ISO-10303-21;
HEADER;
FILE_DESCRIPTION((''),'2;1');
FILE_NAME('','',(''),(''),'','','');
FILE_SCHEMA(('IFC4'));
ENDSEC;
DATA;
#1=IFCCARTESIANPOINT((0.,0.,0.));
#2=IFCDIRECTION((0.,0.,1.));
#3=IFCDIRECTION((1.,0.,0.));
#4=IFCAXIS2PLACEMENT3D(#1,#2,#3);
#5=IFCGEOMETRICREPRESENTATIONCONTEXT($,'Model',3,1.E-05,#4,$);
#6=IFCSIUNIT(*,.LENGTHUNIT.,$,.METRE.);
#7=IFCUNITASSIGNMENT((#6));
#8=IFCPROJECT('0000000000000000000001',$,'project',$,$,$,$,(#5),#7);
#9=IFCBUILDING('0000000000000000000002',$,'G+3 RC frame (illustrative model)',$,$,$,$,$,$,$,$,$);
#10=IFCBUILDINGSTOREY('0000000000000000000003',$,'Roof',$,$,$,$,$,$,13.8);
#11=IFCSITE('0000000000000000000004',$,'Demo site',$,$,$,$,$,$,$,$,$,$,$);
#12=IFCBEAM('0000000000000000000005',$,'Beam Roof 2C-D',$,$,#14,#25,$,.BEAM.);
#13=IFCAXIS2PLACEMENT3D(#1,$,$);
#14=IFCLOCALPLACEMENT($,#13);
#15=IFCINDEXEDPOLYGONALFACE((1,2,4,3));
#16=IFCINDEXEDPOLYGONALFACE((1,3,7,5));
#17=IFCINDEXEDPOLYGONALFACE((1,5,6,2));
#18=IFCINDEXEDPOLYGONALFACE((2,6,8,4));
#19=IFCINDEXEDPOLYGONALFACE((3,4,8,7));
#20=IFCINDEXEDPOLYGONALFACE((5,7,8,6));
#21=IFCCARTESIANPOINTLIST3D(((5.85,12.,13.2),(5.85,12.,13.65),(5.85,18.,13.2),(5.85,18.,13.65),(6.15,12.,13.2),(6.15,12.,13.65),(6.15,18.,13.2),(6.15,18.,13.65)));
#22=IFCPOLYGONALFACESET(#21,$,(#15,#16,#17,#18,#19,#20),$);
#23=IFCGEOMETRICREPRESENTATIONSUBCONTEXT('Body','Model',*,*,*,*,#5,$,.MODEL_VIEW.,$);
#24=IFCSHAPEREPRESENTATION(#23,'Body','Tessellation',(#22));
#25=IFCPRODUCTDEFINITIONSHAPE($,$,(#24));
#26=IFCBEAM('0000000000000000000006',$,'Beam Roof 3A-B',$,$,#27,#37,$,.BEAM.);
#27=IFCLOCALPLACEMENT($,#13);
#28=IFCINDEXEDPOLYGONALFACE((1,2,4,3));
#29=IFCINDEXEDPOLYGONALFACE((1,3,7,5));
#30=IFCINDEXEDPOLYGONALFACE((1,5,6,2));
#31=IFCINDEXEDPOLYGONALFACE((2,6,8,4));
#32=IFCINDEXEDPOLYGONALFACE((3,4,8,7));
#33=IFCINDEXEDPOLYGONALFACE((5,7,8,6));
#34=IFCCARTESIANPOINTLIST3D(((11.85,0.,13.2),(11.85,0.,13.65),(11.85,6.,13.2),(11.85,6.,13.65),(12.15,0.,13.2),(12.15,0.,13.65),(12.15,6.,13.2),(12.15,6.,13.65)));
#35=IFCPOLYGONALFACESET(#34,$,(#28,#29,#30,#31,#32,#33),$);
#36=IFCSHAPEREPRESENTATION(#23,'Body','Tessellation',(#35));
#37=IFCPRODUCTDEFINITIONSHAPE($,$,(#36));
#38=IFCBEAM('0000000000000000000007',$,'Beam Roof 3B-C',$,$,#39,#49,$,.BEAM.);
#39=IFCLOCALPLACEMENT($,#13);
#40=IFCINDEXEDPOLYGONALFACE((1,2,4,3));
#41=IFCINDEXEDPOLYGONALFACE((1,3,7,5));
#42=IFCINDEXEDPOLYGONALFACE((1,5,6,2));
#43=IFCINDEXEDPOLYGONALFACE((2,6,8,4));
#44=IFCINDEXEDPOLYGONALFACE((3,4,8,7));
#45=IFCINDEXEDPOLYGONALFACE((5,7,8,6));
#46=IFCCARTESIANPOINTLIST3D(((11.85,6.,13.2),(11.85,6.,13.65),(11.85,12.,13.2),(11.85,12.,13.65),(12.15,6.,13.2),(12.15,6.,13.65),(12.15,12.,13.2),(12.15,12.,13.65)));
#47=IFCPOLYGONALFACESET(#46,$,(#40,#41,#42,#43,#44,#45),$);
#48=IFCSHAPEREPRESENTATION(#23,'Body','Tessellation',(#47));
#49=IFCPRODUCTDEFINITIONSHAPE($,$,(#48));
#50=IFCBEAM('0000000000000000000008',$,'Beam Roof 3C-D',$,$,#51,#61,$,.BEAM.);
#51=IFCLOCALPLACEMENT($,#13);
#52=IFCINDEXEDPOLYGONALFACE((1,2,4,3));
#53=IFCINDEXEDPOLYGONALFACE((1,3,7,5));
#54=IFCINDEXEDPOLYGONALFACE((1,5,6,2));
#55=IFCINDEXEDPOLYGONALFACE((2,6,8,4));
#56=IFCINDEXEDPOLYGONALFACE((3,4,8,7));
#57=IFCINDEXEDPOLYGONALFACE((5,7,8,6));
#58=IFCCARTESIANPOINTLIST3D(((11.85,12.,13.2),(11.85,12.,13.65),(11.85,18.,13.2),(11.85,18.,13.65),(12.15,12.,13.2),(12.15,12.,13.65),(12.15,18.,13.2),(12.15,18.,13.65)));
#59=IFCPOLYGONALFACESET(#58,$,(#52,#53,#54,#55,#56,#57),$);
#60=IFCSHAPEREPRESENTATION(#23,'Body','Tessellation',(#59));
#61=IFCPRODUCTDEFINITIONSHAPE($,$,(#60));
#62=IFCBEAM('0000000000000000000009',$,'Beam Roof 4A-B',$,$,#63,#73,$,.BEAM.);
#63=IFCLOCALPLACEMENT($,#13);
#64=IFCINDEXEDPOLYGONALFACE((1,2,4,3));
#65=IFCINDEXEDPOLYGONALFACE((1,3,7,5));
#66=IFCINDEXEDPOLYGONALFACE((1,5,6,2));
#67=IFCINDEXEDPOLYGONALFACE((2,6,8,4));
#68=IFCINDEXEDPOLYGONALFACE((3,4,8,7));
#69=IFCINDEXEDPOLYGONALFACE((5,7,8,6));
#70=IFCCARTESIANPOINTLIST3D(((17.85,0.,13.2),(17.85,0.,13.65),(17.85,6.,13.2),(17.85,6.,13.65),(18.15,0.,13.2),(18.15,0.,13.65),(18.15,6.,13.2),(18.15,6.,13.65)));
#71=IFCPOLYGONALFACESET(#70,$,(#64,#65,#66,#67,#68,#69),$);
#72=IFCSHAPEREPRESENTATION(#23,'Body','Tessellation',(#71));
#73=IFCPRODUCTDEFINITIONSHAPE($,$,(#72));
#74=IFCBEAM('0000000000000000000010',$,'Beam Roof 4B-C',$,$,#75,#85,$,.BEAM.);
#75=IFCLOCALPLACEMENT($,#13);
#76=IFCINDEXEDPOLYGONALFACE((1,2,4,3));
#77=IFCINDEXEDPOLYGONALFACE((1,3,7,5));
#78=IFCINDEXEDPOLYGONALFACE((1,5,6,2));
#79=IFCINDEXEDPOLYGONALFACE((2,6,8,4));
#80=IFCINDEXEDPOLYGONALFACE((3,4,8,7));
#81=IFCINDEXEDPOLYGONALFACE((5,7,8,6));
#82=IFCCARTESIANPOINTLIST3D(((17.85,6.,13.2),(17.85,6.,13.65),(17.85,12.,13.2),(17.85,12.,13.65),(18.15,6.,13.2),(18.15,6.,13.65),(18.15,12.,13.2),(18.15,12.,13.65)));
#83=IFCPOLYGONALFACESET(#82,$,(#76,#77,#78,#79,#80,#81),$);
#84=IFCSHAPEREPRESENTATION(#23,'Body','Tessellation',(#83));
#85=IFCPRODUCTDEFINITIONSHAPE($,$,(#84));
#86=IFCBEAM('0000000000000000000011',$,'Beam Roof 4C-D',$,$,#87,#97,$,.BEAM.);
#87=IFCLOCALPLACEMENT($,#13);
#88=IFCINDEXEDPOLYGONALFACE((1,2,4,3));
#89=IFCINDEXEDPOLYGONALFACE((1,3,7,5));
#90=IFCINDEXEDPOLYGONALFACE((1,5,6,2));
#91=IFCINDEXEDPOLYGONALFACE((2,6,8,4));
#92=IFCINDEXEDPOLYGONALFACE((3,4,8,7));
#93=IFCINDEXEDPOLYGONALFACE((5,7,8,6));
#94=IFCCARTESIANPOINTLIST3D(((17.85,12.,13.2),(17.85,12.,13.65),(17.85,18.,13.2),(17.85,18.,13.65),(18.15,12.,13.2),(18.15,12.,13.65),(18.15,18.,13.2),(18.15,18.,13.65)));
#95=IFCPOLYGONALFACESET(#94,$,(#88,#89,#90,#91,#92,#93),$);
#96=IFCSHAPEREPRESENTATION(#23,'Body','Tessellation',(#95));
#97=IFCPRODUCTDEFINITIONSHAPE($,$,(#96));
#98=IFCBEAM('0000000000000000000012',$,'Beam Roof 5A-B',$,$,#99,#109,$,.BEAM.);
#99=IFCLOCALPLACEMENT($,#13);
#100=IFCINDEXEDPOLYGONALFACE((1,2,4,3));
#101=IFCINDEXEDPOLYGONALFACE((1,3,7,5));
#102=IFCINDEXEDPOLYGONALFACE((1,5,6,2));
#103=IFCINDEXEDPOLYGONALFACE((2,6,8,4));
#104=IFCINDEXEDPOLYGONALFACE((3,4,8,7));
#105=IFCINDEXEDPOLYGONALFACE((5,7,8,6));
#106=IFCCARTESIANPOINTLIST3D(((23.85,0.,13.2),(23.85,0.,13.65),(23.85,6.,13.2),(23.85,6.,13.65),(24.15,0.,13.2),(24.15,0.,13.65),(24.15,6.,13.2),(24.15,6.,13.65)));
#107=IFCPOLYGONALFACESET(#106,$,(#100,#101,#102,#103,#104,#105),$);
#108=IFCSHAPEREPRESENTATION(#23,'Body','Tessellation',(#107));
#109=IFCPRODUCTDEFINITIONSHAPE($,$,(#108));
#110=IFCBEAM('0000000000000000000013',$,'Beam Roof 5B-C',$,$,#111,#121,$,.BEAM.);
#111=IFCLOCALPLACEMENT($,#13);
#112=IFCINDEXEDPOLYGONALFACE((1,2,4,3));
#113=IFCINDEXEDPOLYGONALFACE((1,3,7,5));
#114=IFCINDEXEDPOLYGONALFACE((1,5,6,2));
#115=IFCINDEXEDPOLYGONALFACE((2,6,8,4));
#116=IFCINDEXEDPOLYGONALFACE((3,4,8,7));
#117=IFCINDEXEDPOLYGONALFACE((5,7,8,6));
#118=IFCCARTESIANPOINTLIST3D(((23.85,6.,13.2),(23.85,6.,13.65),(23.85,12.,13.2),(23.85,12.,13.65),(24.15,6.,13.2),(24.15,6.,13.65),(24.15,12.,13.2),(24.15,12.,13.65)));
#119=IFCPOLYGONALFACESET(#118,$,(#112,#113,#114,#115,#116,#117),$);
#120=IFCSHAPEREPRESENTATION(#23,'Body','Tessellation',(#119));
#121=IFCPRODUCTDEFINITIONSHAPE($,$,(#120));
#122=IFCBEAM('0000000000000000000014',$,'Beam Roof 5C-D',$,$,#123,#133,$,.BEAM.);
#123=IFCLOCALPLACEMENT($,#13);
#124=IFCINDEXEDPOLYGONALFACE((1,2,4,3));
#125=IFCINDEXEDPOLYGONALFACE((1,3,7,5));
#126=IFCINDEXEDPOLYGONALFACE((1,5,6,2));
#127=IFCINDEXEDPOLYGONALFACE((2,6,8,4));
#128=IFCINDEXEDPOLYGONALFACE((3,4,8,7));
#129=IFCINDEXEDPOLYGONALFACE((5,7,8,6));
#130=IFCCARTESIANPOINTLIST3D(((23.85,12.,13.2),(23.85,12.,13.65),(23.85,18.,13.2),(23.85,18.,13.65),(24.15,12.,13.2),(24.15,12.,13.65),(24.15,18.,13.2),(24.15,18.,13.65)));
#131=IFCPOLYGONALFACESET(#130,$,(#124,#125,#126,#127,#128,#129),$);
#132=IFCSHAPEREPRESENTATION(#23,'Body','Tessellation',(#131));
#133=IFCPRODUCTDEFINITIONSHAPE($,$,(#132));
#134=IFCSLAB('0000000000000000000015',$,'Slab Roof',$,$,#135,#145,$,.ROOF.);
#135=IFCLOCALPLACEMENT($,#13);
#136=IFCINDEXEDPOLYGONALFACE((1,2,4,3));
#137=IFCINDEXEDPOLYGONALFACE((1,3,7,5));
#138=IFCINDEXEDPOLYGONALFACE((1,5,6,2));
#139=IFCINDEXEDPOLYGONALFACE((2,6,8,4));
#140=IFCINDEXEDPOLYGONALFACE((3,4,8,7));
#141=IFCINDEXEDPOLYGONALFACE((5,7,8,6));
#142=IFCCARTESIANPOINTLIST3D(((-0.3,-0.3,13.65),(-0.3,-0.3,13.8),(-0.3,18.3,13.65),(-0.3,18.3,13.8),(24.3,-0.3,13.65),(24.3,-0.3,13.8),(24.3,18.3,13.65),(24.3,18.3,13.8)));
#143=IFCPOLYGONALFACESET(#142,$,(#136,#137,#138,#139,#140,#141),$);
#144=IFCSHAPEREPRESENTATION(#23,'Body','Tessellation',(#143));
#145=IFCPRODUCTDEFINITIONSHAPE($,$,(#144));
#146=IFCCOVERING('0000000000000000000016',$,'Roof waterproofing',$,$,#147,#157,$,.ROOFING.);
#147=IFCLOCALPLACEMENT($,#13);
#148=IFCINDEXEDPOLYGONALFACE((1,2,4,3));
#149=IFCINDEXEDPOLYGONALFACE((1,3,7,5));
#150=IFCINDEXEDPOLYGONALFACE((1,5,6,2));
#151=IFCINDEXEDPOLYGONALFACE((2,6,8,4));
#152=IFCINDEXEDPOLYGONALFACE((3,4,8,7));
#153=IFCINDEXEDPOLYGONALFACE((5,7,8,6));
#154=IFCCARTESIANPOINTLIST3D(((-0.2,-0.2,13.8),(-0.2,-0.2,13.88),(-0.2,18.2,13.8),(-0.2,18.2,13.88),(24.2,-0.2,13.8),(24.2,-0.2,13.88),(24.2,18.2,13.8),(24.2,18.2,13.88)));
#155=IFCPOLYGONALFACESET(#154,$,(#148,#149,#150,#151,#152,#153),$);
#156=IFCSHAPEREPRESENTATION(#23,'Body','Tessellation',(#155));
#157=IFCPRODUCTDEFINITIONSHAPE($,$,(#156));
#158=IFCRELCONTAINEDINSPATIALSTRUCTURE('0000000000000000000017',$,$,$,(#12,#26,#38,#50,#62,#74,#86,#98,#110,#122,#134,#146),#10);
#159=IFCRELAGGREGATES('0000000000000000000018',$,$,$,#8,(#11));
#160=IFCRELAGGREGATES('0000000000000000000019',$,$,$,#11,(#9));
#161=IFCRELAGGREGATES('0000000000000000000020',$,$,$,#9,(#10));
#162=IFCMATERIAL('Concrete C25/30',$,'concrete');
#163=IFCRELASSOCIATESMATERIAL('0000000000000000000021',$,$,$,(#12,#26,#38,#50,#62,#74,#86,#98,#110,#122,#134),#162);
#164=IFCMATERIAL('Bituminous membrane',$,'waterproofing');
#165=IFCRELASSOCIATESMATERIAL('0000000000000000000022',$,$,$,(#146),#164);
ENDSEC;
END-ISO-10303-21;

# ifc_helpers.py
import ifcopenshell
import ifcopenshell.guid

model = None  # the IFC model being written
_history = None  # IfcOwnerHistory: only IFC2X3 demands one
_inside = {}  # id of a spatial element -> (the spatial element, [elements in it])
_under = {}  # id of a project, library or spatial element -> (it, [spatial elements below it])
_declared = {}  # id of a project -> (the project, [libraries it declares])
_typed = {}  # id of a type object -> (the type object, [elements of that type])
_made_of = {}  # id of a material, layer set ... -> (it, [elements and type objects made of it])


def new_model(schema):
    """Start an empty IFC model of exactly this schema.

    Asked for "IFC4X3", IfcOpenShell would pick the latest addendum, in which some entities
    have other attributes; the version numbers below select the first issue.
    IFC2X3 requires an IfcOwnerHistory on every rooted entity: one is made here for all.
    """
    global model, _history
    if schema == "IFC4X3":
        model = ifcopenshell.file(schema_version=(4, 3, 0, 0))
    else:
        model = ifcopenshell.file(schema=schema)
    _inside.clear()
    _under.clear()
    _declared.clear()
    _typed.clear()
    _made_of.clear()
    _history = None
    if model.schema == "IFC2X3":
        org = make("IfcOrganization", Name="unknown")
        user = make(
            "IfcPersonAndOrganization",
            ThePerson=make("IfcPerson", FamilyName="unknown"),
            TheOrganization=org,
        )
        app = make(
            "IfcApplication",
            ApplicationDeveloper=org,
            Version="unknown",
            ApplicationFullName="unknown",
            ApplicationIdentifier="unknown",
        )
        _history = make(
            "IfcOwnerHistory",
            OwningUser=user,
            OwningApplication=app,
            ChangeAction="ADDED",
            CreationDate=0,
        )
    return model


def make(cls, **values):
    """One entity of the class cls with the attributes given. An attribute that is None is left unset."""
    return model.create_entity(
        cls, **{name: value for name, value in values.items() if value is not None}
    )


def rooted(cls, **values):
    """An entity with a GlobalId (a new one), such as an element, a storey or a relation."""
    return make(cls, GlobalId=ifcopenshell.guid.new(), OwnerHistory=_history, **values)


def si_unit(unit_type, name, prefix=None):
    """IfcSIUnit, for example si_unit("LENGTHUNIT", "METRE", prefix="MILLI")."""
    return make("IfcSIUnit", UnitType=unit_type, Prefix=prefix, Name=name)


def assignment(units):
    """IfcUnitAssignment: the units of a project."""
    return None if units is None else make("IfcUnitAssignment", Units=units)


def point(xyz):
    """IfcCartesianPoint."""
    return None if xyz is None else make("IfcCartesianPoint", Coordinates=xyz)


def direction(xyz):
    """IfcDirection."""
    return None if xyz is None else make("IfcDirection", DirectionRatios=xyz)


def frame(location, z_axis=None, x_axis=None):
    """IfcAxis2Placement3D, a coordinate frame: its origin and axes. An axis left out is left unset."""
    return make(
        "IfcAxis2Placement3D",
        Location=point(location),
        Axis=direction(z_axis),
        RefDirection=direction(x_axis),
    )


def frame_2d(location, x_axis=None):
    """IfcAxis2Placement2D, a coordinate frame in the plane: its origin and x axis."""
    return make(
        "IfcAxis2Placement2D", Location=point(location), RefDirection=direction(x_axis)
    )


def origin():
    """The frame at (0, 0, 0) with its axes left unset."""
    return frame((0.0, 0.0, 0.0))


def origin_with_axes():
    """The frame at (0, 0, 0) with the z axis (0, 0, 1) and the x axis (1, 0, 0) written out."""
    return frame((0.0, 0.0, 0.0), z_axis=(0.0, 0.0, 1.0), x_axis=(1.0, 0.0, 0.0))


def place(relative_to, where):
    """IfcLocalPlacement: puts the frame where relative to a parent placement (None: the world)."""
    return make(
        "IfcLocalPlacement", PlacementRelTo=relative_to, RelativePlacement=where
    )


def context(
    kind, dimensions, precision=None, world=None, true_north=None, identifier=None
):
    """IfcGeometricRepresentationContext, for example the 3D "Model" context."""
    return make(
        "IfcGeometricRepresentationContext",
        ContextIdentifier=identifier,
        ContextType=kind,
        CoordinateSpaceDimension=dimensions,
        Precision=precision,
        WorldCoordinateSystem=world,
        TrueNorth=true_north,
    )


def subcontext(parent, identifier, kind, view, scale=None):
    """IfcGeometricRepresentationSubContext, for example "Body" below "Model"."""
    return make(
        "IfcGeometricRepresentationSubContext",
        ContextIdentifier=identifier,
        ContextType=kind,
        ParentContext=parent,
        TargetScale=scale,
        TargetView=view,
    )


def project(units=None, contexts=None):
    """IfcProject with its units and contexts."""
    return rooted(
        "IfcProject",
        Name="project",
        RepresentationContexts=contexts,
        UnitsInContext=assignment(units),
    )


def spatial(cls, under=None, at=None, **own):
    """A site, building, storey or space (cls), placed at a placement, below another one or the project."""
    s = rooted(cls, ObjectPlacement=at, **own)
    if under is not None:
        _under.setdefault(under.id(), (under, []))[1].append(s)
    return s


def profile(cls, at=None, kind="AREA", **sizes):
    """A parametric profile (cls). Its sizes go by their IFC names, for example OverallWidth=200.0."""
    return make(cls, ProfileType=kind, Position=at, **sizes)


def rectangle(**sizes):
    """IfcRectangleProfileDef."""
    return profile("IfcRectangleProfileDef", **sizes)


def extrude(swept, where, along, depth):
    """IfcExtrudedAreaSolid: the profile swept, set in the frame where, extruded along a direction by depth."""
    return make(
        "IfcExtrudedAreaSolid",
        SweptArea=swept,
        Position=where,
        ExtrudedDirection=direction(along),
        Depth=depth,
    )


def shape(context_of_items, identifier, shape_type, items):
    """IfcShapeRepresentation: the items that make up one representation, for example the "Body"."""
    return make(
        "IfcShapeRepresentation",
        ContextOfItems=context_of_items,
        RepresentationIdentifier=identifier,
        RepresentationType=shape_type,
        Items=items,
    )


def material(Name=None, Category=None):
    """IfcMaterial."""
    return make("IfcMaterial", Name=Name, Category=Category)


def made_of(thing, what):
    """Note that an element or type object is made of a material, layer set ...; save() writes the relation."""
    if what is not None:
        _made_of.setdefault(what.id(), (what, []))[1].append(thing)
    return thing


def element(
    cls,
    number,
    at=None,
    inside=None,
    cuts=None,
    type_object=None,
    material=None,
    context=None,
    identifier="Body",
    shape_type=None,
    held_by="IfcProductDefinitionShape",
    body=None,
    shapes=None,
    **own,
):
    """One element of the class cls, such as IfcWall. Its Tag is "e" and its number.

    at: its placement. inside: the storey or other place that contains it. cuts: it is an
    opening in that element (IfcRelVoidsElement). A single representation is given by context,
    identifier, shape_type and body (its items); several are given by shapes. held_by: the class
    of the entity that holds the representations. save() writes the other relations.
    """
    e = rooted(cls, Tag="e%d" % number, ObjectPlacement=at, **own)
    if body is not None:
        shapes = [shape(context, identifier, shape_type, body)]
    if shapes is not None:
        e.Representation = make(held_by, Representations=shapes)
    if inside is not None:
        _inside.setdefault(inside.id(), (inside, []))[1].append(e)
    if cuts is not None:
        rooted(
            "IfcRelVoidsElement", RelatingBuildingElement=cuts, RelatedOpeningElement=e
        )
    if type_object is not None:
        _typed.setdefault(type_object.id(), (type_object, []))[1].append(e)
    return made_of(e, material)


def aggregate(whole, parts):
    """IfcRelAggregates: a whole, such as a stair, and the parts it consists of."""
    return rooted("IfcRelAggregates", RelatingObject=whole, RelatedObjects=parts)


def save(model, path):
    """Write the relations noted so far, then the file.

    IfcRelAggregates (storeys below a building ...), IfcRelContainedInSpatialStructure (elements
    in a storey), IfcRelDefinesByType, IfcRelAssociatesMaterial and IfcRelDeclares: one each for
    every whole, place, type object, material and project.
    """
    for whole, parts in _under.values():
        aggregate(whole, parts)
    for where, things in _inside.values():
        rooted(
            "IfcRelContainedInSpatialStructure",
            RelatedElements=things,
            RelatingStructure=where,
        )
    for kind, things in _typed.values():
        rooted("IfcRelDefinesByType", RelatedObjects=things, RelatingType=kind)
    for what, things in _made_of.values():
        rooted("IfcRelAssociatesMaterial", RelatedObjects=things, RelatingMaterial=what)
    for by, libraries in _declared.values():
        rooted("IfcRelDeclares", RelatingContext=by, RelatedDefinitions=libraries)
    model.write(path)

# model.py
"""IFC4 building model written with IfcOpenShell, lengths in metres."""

from ifc_helpers import new_model, si_unit, frame, frame_2d, origin, origin_with_axes, place, context, subcontext, project, spatial, rectangle, extrude, material, element, save


model = new_model("IFC4")

# Units and contexts
model_context = context("Model", 3, precision=1e-05, world=origin_with_axes())
body_context = subcontext(model_context, "Body", "Model", "MODEL_VIEW")
ifc_project = project(units=[si_unit("LENGTHUNIT", "METRE")], contexts=[model_context])

# Site, building, storey
site = spatial("IfcSite", under=ifc_project, Name="Demo site")
building = spatial("IfcBuilding", under=site, Name="G+3 RC frame (illustrative model)")
storey = spatial("IfcBuildingStorey", under=building, Name="Roof", Elevation=13.8)

# Beams
ifc_material_1 = material(Name="Concrete C25/30", Category="concrete")
for number, where, z_axis, x_axis, name in (
    (1, (5.85, 12.0, 13.2), (0.0, 0.0, 1.0), (1.0, 0.0, 0.0), "Beam Roof 2C-D"),
    (2, (11.85, 0.0, 13.2), (0.0, 0.0, 1.0), (1.0, 0.0, 0.0), "Beam Roof 3A-B"),
    (3, (11.85, 6.0, 13.2), (0.0, 0.0, 1.0), (1.0, 0.0, 0.0), "Beam Roof 3B-C"),
    (4, (11.85, 12.0, 13.2), (0.0, 0.0, 1.0), (1.0, 0.0, 0.0), "Beam Roof 3C-D"),
    (5, (17.85, 0.0, 13.2), (0.0, 0.0, 1.0), (1.0, 0.0, 0.0), "Beam Roof 4A-B"),
    (6, (17.85, 6.0, 13.2), (0.0, 0.0, 1.0), (1.0, 0.0, 0.0), "Beam Roof 4B-C"),
    (7, (17.85, 12.0, 13.2), (0.0, 0.0, 1.0), (1.0, 0.0, 0.0), "Beam Roof 4C-D"),
    (8, (23.85, 0.0, 13.2), (0.0, 0.0, 1.0), (1.0, 0.0, 0.0), "Beam Roof 5A-B"),
    (9, (23.85, 6.0, 13.2), (0.0, 0.0, 1.0), (1.0, 0.0, 0.0), "Beam Roof 5B-C"),
    (10, (23.85, 12.0, 13.2), (0.0, 0.0, 1.0), (1.0, 0.0, 0.0), "Beam Roof 5C-D"),
):
    element("IfcBeam", number, at=place(None, frame(where, z_axis=z_axis, x_axis=x_axis)), inside=storey, material=ifc_material_1, Name=name, PredefinedType="BEAM", context=body_context, shape_type="SweptSolid", body=[
        extrude(rectangle(XDim=0.3, YDim=6.0, at=frame_2d((0.15, 3.0))), origin(), (0.0, 0.0, 1.0), 0.45),
    ])

# Slab
slab_placement = place(None, frame((-0.3, -0.3, 13.65), z_axis=(0.0, 0.0, 1.0), x_axis=(1.0, 0.0, 0.0)))
element("IfcSlab", 11, at=slab_placement, inside=storey, material=ifc_material_1, Name="Slab Roof", PredefinedType="ROOF", context=body_context, shape_type="SweptSolid", body=[
    extrude(rectangle(XDim=24.6, YDim=18.6, at=frame_2d((12.3, 9.3))), origin(), (0.0, 0.0, 1.0), 0.15),
])

# Covering
ifc_material_2 = material(Name="Bituminous membrane", Category="waterproofing")
covering_placement = place(None, frame((-0.2, -0.2, 13.8), z_axis=(0.0, 0.0, 1.0), x_axis=(1.0, 0.0, 0.0)))
element("IfcCovering", 12, at=covering_placement, inside=storey, material=ifc_material_2, Name="Roof waterproofing", PredefinedType="ROOFING", context=body_context, shape_type="SweptSolid", body=[
    extrude(rectangle(XDim=24.4, YDim=18.4, at=frame_2d((12.2, 9.2))), origin(), (0.0, 0.0, 1.0), 0.08),
])

save(model, "model.ifc")
